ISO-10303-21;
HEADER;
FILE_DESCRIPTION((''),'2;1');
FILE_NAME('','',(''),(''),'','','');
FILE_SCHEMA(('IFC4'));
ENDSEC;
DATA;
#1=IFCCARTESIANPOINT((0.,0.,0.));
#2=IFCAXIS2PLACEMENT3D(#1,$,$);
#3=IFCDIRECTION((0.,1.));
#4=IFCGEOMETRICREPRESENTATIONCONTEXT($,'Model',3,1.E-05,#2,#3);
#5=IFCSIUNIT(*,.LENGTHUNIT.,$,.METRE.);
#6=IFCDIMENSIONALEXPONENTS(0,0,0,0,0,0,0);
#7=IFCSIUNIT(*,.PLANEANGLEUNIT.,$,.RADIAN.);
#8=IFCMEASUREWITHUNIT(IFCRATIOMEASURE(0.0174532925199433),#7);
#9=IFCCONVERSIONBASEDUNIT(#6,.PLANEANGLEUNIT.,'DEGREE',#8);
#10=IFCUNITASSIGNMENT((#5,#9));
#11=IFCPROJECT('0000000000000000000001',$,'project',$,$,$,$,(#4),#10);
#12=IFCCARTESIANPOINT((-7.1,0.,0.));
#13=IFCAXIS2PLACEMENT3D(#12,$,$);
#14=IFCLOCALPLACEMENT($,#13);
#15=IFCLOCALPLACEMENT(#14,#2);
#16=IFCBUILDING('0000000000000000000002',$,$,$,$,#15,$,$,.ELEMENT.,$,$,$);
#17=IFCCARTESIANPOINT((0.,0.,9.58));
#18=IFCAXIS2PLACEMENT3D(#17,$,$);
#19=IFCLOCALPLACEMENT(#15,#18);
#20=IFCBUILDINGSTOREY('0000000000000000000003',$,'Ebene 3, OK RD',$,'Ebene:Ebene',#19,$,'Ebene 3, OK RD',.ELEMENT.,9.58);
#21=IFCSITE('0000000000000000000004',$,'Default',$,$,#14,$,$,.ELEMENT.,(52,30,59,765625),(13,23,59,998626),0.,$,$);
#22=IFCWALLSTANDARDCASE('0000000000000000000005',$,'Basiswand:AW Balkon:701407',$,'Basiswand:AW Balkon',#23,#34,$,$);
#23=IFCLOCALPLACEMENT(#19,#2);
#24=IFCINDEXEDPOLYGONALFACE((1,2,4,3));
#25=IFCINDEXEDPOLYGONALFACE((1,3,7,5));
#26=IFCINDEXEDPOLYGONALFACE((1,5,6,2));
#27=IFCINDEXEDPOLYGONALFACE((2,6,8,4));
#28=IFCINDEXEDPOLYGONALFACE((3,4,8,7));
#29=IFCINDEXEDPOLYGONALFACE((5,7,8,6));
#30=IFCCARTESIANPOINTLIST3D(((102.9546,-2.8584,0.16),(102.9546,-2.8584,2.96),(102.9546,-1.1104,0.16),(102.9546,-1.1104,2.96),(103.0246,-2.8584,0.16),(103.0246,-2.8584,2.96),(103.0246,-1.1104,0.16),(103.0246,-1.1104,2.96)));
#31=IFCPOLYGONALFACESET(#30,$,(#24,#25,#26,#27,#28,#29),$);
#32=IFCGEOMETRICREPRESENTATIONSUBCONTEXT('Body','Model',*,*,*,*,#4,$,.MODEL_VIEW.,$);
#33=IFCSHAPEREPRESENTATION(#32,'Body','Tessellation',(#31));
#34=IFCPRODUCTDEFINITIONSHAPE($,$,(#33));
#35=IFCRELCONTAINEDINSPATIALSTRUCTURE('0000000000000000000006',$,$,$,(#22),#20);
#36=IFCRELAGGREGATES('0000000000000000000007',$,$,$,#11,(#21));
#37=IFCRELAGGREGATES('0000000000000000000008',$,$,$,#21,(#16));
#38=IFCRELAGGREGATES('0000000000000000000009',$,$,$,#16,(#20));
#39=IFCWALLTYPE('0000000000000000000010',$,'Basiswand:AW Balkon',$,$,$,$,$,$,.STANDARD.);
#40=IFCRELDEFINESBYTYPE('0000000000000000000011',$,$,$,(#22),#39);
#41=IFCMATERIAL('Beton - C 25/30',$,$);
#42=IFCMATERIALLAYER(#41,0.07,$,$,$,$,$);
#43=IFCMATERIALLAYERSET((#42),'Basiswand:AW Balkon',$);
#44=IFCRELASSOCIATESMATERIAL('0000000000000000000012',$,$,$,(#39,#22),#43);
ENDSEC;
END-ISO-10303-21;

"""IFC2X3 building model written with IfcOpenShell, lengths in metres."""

from ifc_helpers import new_model, entity, si_unit, converted_unit, direction, frame, frame_2d, origin, place, context, subcontext, project, spatial, rectangle, extrude, material, layer, layer_set, layer_usage, type_object, element, save


model = new_model("IFC2X3")

# Units and contexts
model_context = context("Model", 3, precision=1e-05, world=origin(), true_north=direction((0.0, 1.0)))
body_context = subcontext(model_context, "Body", "Model", "MODEL_VIEW")
ifc_project = project(units=[si_unit("LENGTHUNIT", "METRE"), converted_unit("PLANEANGLEUNIT", "DEGREE", entity("IfcRatioMeasure", 0.0174532925199433), si_unit("PLANEANGLEUNIT", "RADIAN"), dimensions=[0, 0, 0, 0, 0, 0, 0])], contexts=[model_context])

# Site, building, storey
site_placement = place(None, frame((-7.1, 0.0, 0.0)))
site = spatial("IfcSite", under=ifc_project, at=site_placement, Name="Default", CompositionType="ELEMENT", RefLatitude=(52, 30, 59, 765625), RefLongitude=(13, 23, 59, 998626), RefElevation=0.0)
building_placement = place(site_placement, origin())
building = spatial("IfcBuilding", under=site, at=building_placement, CompositionType="ELEMENT")
storey_placement = place(building_placement, frame((0.0, 0.0, 9.58)))
storey = spatial("IfcBuildingStorey", under=building, at=storey_placement, Name="Ebene 3, OK RD", ObjectType="Ebene:Ebene", LongName="Ebene 3, OK RD", CompositionType="ELEMENT", Elevation=9.58)

# Wall
ifc_material_1 = material(Name="Beton - C 25/30")
ifc_layer_1 = layer(ifc_material_1, 0.07)
ifc_layer_set_1 = layer_set([ifc_layer_1], Name="Basiswand:AW Balkon")
ifc_layer_usage_1 = layer_usage(ifc_layer_set_1, "AXIS2", "NEGATIVE", 0.035)
wall_type_1 = type_object("IfcWallType", Name="Basiswand:AW Balkon", PredefinedType="STANDARD", material=ifc_layer_set_1)
wall_1_placement = place(storey_placement, frame((102.9896, -2.8584, 0.16), z_axis=(0.0, 0.0, 1.0), x_axis=(0.0, 1.0, 0.0)))
element("IfcWallStandardCase", 1, at=wall_1_placement, inside=storey, type_object=wall_type_1, material=ifc_layer_usage_1, Name="Basiswand:AW Balkon:701407", ObjectType="Basiswand:AW Balkon", context=body_context, shape_type="SweptSolid", body=[
    extrude(rectangle(XDim=1.748, YDim=0.07, at=frame_2d((0.874, 0.0), x_axis=(-1.0, 0.0))), origin(), (0.0, 0.0, 1.0), 2.8),
])

save(model, "model.ifc")
